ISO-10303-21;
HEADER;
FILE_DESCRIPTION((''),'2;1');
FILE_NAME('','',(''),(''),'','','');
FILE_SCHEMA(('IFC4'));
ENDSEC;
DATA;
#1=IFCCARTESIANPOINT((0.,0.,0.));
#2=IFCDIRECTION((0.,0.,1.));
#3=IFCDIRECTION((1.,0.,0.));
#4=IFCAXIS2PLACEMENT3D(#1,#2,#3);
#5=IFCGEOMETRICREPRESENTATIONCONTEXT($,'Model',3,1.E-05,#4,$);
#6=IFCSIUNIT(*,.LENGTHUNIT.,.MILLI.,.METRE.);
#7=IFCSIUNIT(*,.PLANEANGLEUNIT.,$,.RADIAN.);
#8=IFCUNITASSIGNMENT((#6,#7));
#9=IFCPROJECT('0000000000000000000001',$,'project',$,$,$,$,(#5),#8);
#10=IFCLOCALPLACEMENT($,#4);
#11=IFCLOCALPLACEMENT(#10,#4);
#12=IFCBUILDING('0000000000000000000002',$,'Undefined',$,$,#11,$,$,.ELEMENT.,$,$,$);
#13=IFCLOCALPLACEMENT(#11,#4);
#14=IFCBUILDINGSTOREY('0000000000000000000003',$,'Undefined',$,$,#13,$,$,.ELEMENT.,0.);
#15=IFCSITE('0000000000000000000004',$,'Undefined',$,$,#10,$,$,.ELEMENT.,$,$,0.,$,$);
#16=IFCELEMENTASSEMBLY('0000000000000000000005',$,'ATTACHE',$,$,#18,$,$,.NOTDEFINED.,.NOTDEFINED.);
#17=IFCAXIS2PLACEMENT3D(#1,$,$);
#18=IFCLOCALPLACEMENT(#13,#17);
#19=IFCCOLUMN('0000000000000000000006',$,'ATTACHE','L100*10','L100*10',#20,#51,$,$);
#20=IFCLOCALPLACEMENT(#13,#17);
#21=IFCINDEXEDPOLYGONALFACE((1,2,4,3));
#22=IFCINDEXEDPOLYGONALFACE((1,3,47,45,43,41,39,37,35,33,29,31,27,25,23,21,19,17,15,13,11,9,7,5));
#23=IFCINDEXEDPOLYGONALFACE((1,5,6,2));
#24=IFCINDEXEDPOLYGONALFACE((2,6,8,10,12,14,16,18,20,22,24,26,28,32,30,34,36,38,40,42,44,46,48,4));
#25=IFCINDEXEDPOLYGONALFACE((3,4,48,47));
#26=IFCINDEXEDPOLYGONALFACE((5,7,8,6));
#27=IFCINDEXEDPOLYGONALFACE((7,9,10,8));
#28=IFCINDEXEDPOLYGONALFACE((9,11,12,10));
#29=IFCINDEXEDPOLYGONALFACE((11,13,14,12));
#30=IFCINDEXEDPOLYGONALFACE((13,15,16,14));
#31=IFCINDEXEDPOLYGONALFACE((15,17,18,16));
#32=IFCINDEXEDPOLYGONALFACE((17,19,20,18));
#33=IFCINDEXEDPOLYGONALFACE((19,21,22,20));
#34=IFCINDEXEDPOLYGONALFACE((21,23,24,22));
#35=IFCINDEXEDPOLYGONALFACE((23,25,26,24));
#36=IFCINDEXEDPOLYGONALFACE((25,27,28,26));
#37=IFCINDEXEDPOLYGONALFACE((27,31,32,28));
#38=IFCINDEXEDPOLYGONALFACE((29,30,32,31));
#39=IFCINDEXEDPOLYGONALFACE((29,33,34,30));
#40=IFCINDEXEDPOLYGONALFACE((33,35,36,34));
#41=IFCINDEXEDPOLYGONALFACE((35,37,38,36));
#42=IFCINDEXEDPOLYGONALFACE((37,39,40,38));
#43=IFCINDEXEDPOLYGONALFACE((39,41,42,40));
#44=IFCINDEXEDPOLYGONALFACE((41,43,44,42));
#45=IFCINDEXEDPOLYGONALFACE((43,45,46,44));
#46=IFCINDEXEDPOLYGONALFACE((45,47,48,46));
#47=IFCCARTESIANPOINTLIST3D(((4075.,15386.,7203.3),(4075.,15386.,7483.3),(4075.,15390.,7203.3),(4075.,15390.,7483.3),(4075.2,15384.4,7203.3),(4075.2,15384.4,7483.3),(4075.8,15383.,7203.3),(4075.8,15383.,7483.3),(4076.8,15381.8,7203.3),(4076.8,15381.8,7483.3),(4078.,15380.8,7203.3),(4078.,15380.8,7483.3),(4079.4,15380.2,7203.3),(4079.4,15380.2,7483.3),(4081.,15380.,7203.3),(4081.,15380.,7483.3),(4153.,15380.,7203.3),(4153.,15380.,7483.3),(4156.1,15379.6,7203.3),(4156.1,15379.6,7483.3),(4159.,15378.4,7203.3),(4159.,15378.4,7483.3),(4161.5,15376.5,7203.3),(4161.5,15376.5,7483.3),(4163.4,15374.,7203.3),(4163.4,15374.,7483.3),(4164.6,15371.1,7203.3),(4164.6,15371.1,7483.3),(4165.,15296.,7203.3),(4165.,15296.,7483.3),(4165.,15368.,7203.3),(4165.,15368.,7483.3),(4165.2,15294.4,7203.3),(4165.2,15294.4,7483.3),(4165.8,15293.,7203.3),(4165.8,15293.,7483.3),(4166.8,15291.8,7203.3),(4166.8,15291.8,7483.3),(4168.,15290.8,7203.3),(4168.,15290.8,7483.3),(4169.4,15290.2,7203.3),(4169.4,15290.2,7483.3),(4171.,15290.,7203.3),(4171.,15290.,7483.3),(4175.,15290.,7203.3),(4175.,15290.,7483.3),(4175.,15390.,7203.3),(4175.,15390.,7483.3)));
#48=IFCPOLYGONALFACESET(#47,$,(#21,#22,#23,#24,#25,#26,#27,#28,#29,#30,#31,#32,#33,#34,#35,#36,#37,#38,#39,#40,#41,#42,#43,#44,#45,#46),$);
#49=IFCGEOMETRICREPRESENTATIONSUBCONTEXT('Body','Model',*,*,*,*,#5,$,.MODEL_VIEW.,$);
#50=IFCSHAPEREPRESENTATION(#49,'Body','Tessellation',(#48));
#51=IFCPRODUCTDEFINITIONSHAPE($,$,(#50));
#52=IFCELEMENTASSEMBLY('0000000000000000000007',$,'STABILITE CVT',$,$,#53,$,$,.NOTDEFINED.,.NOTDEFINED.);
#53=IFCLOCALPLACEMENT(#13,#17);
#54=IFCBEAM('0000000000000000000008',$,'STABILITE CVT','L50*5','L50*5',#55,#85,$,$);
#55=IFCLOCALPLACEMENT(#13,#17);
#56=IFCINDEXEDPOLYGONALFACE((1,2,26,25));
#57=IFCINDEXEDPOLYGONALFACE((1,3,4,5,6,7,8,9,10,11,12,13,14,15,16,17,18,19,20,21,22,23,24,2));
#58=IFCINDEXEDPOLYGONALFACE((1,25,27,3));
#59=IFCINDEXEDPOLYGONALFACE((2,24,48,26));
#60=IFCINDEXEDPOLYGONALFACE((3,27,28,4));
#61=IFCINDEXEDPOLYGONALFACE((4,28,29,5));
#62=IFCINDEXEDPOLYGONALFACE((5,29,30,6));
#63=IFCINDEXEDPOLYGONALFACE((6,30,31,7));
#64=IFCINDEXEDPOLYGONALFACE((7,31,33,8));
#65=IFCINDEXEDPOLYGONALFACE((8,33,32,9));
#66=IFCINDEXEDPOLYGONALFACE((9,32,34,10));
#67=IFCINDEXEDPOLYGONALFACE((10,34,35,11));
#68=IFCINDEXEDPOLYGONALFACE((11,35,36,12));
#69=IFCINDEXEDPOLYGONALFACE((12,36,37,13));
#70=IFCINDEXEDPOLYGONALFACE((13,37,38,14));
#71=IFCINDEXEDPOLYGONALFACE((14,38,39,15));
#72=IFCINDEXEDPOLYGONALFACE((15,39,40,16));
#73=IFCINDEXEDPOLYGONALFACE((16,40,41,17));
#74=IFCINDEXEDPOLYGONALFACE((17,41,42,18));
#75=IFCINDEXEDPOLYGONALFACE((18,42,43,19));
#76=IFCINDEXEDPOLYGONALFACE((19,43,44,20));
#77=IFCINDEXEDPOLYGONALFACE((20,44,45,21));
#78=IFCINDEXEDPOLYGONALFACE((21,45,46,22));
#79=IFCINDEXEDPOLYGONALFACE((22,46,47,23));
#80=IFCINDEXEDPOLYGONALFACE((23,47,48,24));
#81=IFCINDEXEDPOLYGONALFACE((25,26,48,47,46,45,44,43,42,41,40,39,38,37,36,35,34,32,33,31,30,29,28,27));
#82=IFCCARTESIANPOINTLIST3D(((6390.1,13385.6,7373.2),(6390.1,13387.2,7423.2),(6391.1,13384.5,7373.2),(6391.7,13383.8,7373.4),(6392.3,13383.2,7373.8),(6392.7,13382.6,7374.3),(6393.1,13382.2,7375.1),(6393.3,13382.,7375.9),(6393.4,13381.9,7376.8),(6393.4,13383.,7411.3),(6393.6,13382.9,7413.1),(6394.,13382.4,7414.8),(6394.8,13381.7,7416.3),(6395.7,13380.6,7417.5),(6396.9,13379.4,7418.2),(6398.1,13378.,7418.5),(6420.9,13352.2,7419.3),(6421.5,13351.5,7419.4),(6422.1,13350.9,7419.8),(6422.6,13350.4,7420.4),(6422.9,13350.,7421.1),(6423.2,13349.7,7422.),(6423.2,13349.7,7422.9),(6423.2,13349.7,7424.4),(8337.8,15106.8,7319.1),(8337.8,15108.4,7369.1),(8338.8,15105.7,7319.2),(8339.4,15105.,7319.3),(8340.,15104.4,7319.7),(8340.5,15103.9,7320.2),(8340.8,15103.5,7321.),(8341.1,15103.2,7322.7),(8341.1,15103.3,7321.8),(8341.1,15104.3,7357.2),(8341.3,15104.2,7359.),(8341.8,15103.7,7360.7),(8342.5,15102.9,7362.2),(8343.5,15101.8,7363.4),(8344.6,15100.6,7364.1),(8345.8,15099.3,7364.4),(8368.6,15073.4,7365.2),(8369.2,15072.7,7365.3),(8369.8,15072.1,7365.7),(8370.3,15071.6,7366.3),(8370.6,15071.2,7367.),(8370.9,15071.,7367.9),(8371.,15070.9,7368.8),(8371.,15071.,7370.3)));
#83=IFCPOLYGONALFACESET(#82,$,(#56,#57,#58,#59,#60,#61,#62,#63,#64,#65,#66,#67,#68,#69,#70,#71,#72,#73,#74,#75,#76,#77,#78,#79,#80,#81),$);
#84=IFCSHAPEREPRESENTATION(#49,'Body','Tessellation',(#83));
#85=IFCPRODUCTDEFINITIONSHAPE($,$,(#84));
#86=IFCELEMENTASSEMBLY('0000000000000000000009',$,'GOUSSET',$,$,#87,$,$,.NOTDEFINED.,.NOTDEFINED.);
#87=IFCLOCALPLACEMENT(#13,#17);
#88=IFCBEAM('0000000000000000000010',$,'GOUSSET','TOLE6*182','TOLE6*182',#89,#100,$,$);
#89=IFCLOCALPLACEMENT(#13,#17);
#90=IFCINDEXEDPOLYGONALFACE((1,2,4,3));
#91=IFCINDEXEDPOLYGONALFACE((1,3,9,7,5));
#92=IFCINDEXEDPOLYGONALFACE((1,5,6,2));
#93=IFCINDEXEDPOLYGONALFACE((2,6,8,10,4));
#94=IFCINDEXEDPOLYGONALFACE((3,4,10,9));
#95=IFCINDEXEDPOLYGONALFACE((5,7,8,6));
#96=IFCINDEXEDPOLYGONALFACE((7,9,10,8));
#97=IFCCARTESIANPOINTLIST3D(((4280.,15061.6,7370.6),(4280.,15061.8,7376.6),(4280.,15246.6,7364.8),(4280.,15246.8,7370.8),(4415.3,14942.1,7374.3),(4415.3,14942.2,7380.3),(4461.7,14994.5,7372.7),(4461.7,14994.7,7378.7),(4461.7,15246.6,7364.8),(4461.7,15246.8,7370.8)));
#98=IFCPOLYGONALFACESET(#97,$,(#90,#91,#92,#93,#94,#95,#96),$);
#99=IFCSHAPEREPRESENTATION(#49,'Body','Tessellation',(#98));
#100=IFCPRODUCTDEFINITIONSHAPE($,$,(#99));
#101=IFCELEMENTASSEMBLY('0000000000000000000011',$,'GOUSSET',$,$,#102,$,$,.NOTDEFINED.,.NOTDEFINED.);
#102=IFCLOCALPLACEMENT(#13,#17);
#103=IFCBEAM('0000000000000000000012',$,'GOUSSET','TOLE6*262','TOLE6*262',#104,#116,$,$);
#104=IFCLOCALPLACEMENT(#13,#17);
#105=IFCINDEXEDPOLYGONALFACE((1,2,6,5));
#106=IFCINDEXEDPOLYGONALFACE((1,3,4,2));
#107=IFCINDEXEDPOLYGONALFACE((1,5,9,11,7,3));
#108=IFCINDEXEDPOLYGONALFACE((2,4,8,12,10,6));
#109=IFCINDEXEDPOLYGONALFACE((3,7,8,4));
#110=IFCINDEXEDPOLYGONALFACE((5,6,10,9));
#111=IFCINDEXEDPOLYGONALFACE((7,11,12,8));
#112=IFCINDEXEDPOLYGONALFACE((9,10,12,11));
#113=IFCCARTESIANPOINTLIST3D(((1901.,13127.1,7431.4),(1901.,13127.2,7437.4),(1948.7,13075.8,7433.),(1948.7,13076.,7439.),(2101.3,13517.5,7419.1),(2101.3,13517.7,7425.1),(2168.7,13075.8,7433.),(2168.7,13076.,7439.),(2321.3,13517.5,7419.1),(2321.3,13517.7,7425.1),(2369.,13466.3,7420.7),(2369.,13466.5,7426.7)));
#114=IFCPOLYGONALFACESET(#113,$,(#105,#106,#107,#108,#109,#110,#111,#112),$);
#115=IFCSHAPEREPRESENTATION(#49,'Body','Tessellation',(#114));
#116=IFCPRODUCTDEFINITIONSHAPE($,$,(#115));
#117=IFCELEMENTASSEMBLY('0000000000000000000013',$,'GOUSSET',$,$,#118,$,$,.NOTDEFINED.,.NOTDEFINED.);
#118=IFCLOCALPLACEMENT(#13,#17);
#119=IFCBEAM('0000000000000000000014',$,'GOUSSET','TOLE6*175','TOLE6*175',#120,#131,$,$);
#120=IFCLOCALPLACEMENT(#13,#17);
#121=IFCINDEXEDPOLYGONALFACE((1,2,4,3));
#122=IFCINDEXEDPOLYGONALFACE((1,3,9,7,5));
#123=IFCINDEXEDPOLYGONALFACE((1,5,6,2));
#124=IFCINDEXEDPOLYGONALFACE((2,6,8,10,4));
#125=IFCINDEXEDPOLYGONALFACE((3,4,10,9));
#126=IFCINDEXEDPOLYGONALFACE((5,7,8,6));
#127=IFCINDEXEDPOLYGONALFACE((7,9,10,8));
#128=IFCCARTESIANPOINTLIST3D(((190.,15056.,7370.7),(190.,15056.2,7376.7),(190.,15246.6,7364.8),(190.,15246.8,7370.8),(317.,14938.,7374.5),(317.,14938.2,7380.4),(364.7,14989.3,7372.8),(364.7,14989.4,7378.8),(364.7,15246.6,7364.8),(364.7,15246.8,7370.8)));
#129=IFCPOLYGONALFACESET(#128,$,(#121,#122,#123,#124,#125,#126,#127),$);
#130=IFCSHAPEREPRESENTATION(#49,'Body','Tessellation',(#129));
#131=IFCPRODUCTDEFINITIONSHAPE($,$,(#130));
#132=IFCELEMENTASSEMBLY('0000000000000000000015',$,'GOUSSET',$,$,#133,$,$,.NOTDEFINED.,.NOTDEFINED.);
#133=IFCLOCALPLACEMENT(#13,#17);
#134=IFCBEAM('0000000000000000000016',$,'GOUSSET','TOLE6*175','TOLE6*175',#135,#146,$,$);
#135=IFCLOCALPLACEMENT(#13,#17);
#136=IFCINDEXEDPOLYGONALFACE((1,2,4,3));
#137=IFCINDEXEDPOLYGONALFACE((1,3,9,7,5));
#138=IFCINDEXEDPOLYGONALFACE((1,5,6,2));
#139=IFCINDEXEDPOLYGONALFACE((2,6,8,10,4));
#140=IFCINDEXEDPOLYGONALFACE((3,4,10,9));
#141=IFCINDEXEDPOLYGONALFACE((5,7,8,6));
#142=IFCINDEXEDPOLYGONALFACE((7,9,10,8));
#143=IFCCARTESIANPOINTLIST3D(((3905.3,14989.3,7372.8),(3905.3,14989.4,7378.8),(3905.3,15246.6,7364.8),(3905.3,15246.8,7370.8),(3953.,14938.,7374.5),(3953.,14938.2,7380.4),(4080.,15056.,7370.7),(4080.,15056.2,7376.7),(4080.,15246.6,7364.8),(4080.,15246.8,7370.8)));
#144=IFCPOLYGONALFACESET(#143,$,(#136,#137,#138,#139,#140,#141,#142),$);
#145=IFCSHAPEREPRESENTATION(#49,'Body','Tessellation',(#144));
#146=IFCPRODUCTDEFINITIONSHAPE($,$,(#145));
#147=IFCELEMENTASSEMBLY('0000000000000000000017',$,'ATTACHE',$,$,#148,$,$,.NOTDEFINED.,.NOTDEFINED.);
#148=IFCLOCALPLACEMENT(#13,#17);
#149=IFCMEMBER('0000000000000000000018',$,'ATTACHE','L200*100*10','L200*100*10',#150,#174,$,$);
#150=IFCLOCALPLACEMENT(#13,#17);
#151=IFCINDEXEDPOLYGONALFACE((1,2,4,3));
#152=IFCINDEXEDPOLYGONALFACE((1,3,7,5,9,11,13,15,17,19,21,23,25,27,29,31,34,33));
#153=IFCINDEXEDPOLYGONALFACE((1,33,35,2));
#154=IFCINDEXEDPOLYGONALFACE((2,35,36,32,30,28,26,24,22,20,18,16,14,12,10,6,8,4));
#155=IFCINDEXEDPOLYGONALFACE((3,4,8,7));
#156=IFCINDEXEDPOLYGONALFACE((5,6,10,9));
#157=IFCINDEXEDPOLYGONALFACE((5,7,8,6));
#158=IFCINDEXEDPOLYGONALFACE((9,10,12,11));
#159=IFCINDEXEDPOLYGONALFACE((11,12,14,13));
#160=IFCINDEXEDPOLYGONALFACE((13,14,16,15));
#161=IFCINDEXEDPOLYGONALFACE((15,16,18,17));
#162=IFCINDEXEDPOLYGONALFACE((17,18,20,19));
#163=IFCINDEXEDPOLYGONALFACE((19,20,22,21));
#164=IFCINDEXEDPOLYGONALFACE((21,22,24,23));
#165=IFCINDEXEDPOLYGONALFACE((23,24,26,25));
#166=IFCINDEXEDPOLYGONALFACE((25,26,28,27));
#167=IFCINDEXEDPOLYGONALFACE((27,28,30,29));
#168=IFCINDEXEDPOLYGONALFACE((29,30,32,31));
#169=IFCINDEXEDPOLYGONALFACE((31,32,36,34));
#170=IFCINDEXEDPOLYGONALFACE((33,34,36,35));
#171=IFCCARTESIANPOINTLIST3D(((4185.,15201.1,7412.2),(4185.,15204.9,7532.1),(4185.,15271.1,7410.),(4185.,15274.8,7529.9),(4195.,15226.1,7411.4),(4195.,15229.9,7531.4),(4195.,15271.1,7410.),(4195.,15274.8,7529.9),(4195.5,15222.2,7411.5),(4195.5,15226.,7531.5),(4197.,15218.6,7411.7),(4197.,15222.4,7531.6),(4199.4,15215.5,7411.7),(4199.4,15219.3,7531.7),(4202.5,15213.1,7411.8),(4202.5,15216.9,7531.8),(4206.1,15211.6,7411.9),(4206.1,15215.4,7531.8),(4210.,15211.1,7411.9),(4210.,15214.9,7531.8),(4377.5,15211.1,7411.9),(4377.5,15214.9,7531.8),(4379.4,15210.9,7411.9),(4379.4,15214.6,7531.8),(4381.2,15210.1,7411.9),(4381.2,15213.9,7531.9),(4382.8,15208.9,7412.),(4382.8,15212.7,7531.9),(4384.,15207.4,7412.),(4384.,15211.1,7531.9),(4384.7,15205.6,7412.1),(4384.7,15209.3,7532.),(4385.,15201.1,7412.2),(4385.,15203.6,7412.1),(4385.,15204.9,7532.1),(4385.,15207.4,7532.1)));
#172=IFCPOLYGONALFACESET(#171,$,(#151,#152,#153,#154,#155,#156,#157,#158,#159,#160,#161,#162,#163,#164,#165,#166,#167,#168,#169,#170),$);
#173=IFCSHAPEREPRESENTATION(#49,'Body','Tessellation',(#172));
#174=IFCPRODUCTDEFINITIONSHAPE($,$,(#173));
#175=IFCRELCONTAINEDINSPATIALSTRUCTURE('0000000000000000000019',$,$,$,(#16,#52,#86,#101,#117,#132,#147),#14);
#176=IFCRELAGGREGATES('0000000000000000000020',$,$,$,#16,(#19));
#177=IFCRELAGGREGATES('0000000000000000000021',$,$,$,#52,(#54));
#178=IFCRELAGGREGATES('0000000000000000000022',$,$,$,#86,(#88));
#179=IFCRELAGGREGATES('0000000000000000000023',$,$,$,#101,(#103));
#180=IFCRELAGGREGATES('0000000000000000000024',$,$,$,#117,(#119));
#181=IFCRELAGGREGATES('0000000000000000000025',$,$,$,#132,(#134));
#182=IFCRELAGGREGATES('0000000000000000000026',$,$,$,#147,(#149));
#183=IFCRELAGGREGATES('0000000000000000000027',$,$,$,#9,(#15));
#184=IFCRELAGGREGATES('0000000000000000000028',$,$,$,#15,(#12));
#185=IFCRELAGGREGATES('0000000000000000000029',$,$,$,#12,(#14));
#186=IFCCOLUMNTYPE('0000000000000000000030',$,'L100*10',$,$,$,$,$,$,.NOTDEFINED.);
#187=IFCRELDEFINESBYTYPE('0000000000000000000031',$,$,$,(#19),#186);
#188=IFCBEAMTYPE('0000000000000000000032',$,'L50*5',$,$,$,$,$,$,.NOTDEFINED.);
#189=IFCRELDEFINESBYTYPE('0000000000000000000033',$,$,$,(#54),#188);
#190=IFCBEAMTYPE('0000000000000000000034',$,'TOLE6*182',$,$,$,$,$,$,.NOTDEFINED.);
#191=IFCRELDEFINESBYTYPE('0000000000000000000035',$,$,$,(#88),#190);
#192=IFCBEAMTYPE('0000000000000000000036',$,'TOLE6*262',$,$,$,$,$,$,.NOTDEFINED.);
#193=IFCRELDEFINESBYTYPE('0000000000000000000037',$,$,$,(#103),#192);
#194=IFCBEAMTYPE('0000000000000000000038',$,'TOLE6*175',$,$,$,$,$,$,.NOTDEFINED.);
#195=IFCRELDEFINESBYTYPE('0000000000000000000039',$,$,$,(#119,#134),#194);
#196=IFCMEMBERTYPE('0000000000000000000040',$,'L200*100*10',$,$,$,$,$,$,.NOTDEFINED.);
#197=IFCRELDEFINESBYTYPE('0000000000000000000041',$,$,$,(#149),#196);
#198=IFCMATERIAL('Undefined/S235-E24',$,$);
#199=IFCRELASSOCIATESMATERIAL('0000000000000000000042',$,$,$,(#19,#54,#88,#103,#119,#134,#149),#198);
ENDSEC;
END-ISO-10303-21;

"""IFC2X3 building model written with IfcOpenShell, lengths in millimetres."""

from ifc_helpers import new_model, si_unit, frame, origin_with_axes, origin_2d_with_axis, place, context, subcontext, project, spatial, polyline, l_section, outline, extrude, clip, halfspace, material, type_object, element, aggregate, save


model = new_model("IFC2X3")

# Units and contexts
model_context = context("Model", 3, precision=1e-05, world=origin_with_axes())
body_context = subcontext(model_context, "Body", "Model", "MODEL_VIEW")
ifc_project = project(units=[si_unit("LENGTHUNIT", "METRE", prefix="MILLI"), si_unit("PLANEANGLEUNIT", "RADIAN")], contexts=[model_context])

# Site, building, storey
site_placement = place(None, origin_with_axes())
site = spatial("IfcSite", under=ifc_project, at=site_placement, Name="Undefined", CompositionType="ELEMENT", RefElevation=0.0)
building_placement = place(site_placement, origin_with_axes())
building = spatial("IfcBuilding", under=site, at=building_placement, Name="Undefined", CompositionType="ELEMENT")
storey_placement = place(building_placement, origin_with_axes())
storey = spatial("IfcBuildingStorey", under=building, at=storey_placement, Name="Undefined", CompositionType="ELEMENT", Elevation=0.0)

# Element assembly, column
assembly_1_placement = place(storey_placement, origin_with_axes())
assembly_1 = element("IfcElementAssembly", 1, at=assembly_1_placement, inside=storey, Name="ATTACHE", AssemblyPlace="NOTDEFINED", PredefinedType="NOTDEFINED")
ifc_material_1 = material(Name="Undefined/S235-E24")
column_type = type_object("IfcColumnType", Name="L100*10", PredefinedType="NOTDEFINED")
column_placement = place(assembly_1_placement, frame((4125.0, 15340.0, 7203.3), z_axis=(0.0, 0.0, 1.0), x_axis=(-1.0, 0.0, 0.0)))
column = element("IfcColumn", 2, at=column_placement, type_object=column_type, material=ifc_material_1, Name="ATTACHE", Description="L100*10", ObjectType="L100*10", context=body_context, shape_type="SweptSolid", body=[
    extrude(l_section(Depth=100.0, Width=100.0, Thickness=10.0, FilletRadius=12.0, EdgeRadius=6.0, at=origin_2d_with_axis()), frame((0.0, 0.0, 280.0), z_axis=(0.0, 0.0, -1.0), x_axis=(0.0, 1.0, 0.0)), (0.0, 0.0, 1.0), 280.0),
])
aggregate(assembly_1, [column])

# Element assemblies, beams
assembly_2_placement = place(storey_placement, origin_with_axes())
assembly_2 = element("IfcElementAssembly", 3, at=assembly_2_placement, inside=storey, Name="STABILITE CVT", AssemblyPlace="NOTDEFINED", PredefinedType="NOTDEFINED")
beam_type_1 = type_object("IfcBeamType", Name="L50*5", PredefinedType="NOTDEFINED")
beam_1_placement = place(assembly_2_placement, frame((6328.0, 13298.1, 7401.0), z_axis=(0.662382, -0.748797, 0.023532), x_axis=(0.749167, 0.662055, -0.020805)))
beam_1 = element("IfcBeam", 4, at=beam_1_placement, type_object=beam_type_1, material=ifc_material_1, Name="STABILITE CVT", Description="L50*5", ObjectType="L50*5", context=body_context, shape_type="Clipping", body=[
    clip(clip(extrude(l_section(Depth=50.0, Width=50.0, Thickness=5.0, FilletRadius=7.0, EdgeRadius=3.5, at=origin_2d_with_axis()), frame((2869.9, 0.0, 0.0), z_axis=(-1.0, 0.0, 0.0), x_axis=(0.0, -1.0, 0.0)), (0.0, 0.0, 1.0), 2816.1), halfspace(frame((2704.8, 25.0, 25.0), z_axis=(1.0, -0.000002, 0.0), x_axis=(0.0, 0.000002, -1.0)), False)), halfspace(frame((105.0, 31.0, -25.0), z_axis=(-1.0, 0.000002, 0.0), x_axis=(0.000002, 1.0, 0.0)), False)),
])
aggregate(assembly_2, [beam_1])
assembly_3_placement = place(storey_placement, origin_with_axes())
assembly_3 = element("IfcElementAssembly", 5, at=assembly_3_placement, inside=storey, Name="GOUSSET", AssemblyPlace="NOTDEFINED", PredefinedType="NOTDEFINED")
beam_type_2 = type_object("IfcBeamType", Name="TOLE6*182", PredefinedType="NOTDEFINED")
beam_2_placement = place(assembly_3_placement, frame((4415.3, 14942.1, 7377.3), z_axis=(0.0, -0.031411, -0.999507), x_axis=(-0.749167, 0.662055, -0.020806)))
beam_2 = element("IfcBeam", 6, at=beam_2_placement, type_object=beam_type_2, material=ifc_material_1, Name="GOUSSET", Description="TOLE6*182", ObjectType="TOLE6*182", context=body_context, shape_type="SweptSolid", body=[
    extrude(outline(polyline([(0.0, 0.0), (180.6, 0.0), (303.2, 138.7), (167.1, 259.0), (0.0, 70.0), (0.0, 0.0)])), frame((0.0, 0.0, -3.0), z_axis=(0.0, 0.0, 1.0), x_axis=(1.0, 0.0, 0.0)), (0.0, 0.0, 1.0), 6.0),
])
aggregate(assembly_3, [beam_2])
assembly_4_placement = place(storey_placement, origin_with_axes())
assembly_4 = element("IfcElementAssembly", 7, at=assembly_4_placement, inside=storey, Name="GOUSSET", AssemblyPlace="NOTDEFINED", PredefinedType="NOTDEFINED")
beam_type_3 = type_object("IfcBeamType", Name="TOLE6*262", PredefinedType="NOTDEFINED")
beam_3_placement = place(assembly_4_placement, frame((2321.3, 13517.6, 7422.1), z_axis=(0.0, 0.031411, 0.999507), x_axis=(-1.0, 0.0, 0.0)))
beam_3 = element("IfcBeam", 8, at=beam_3_placement, type_object=beam_type_3, material=ifc_material_1, Name="GOUSSET", Description="TOLE6*262", ObjectType="TOLE6*262", context=body_context, shape_type="SweptSolid", body=[
    extrude(outline(polyline([(0.0, 0.0), (220.0, 0.0), (420.3, 390.7), (372.6, 441.9), (152.6, 441.9), (-47.7, 51.3), (0.0, 0.0)])), frame((0.0, 0.0, -3.0), z_axis=(0.0, 0.0, 1.0), x_axis=(1.0, 0.0, 0.0)), (0.0, 0.0, 1.0), 6.0),
])
aggregate(assembly_4, [beam_3])
assembly_5_placement = place(storey_placement, origin_with_axes())
assembly_5 = element("IfcElementAssembly", 9, at=assembly_5_placement, inside=storey, Name="GOUSSET", AssemblyPlace="NOTDEFINED", PredefinedType="NOTDEFINED")
beam_type_4 = type_object("IfcBeamType", Name="TOLE6*175", PredefinedType="NOTDEFINED")
beam_4_placement = place(assembly_5_placement, frame((317.0, 14938.1, 7377.5), z_axis=(0.0, -0.031411, -0.999507), x_axis=(-0.732435, 0.680502, -0.021386)))
beam_4 = element("IfcBeam", 10, at=beam_4_placement, type_object=beam_type_4, material=ifc_material_1, Name="GOUSSET", Description="TOLE6*175", ObjectType="TOLE6*175", context=body_context, shape_type="SweptSolid", body=[
    extrude(outline(polyline([(0.0, 0.0), (173.4, 0.0), (303.3, 139.7), (175.3, 258.6), (0.0, 70.0), (0.0, 0.0)])), frame((0.0, 0.0, -3.0), z_axis=(0.0, 0.0, 1.0), x_axis=(1.0, 0.0, 0.0)), (0.0, 0.0, 1.0), 6.0),
])
aggregate(assembly_5, [beam_4])
assembly_6_placement = place(storey_placement, origin_with_axes())
assembly_6 = element("IfcElementAssembly", 11, at=assembly_6_placement, inside=storey, Name="GOUSSET", AssemblyPlace="NOTDEFINED", PredefinedType="NOTDEFINED")
beam_5_placement = place(assembly_6_placement, frame((3953.0, 14938.1, 7377.5), z_axis=(0.0, 0.031411, 0.999507), x_axis=(0.732435, 0.680502, -0.021386)))
beam_5 = element("IfcBeam", 12, at=beam_5_placement, type_object=beam_type_4, material=ifc_material_1, Name="GOUSSET", Description="TOLE6*175", ObjectType="TOLE6*175", context=body_context, shape_type="SweptSolid", body=[
    extrude(outline(polyline([(0.0, 0.0), (173.4, 0.0), (303.3, 139.7), (175.3, 258.6), (0.0, 70.0), (0.0, 0.0)])), frame((0.0, 0.0, -3.0), z_axis=(0.0, 0.0, 1.0), x_axis=(1.0, 0.0, 0.0)), (0.0, 0.0, 1.0), 6.0),
])
aggregate(assembly_6, [beam_5])

# Element assembly, member
assembly_7_placement = place(storey_placement, origin_with_axes())
assembly_7 = element("IfcElementAssembly", 13, at=assembly_7_placement, inside=storey, Name="ATTACHE", AssemblyPlace="NOTDEFINED", PredefinedType="NOTDEFINED")
member_type = type_object("IfcMemberType", Name="L200*100*10", PredefinedType="NOTDEFINED")
member_1_placement = place(assembly_7_placement, frame((4285.0, 15251.1, 7410.6), z_axis=(1.0, 0.0, 0.0), x_axis=(0.0, 0.031411, 0.999507)))
member_1 = element("IfcMember", 14, at=member_1_placement, type_object=member_type, material=ifc_material_1, Name="ATTACHE", Description="L200*100*10", ObjectType="L200*100*10", context=body_context, shape_type="Clipping", body=[
    clip(extrude(l_section(Depth=200.0, Width=100.0, Thickness=10.0, FilletRadius=15.0, EdgeRadius=7.5, at=origin_2d_with_axis()), frame((120.0, 0.0, 0.0), z_axis=(-1.0, 0.0, 0.0), x_axis=(0.0, -1.0, 0.0)), (0.0, 0.0, 1.0), 120.0), halfspace(frame((0.0, -20.0, -100.0), z_axis=(0.0, -1.0, 0.000019), x_axis=(0.0, 0.000019, 1.0)), False)),
])
aggregate(assembly_7, [member_1])

save(model, "model.ifc")
